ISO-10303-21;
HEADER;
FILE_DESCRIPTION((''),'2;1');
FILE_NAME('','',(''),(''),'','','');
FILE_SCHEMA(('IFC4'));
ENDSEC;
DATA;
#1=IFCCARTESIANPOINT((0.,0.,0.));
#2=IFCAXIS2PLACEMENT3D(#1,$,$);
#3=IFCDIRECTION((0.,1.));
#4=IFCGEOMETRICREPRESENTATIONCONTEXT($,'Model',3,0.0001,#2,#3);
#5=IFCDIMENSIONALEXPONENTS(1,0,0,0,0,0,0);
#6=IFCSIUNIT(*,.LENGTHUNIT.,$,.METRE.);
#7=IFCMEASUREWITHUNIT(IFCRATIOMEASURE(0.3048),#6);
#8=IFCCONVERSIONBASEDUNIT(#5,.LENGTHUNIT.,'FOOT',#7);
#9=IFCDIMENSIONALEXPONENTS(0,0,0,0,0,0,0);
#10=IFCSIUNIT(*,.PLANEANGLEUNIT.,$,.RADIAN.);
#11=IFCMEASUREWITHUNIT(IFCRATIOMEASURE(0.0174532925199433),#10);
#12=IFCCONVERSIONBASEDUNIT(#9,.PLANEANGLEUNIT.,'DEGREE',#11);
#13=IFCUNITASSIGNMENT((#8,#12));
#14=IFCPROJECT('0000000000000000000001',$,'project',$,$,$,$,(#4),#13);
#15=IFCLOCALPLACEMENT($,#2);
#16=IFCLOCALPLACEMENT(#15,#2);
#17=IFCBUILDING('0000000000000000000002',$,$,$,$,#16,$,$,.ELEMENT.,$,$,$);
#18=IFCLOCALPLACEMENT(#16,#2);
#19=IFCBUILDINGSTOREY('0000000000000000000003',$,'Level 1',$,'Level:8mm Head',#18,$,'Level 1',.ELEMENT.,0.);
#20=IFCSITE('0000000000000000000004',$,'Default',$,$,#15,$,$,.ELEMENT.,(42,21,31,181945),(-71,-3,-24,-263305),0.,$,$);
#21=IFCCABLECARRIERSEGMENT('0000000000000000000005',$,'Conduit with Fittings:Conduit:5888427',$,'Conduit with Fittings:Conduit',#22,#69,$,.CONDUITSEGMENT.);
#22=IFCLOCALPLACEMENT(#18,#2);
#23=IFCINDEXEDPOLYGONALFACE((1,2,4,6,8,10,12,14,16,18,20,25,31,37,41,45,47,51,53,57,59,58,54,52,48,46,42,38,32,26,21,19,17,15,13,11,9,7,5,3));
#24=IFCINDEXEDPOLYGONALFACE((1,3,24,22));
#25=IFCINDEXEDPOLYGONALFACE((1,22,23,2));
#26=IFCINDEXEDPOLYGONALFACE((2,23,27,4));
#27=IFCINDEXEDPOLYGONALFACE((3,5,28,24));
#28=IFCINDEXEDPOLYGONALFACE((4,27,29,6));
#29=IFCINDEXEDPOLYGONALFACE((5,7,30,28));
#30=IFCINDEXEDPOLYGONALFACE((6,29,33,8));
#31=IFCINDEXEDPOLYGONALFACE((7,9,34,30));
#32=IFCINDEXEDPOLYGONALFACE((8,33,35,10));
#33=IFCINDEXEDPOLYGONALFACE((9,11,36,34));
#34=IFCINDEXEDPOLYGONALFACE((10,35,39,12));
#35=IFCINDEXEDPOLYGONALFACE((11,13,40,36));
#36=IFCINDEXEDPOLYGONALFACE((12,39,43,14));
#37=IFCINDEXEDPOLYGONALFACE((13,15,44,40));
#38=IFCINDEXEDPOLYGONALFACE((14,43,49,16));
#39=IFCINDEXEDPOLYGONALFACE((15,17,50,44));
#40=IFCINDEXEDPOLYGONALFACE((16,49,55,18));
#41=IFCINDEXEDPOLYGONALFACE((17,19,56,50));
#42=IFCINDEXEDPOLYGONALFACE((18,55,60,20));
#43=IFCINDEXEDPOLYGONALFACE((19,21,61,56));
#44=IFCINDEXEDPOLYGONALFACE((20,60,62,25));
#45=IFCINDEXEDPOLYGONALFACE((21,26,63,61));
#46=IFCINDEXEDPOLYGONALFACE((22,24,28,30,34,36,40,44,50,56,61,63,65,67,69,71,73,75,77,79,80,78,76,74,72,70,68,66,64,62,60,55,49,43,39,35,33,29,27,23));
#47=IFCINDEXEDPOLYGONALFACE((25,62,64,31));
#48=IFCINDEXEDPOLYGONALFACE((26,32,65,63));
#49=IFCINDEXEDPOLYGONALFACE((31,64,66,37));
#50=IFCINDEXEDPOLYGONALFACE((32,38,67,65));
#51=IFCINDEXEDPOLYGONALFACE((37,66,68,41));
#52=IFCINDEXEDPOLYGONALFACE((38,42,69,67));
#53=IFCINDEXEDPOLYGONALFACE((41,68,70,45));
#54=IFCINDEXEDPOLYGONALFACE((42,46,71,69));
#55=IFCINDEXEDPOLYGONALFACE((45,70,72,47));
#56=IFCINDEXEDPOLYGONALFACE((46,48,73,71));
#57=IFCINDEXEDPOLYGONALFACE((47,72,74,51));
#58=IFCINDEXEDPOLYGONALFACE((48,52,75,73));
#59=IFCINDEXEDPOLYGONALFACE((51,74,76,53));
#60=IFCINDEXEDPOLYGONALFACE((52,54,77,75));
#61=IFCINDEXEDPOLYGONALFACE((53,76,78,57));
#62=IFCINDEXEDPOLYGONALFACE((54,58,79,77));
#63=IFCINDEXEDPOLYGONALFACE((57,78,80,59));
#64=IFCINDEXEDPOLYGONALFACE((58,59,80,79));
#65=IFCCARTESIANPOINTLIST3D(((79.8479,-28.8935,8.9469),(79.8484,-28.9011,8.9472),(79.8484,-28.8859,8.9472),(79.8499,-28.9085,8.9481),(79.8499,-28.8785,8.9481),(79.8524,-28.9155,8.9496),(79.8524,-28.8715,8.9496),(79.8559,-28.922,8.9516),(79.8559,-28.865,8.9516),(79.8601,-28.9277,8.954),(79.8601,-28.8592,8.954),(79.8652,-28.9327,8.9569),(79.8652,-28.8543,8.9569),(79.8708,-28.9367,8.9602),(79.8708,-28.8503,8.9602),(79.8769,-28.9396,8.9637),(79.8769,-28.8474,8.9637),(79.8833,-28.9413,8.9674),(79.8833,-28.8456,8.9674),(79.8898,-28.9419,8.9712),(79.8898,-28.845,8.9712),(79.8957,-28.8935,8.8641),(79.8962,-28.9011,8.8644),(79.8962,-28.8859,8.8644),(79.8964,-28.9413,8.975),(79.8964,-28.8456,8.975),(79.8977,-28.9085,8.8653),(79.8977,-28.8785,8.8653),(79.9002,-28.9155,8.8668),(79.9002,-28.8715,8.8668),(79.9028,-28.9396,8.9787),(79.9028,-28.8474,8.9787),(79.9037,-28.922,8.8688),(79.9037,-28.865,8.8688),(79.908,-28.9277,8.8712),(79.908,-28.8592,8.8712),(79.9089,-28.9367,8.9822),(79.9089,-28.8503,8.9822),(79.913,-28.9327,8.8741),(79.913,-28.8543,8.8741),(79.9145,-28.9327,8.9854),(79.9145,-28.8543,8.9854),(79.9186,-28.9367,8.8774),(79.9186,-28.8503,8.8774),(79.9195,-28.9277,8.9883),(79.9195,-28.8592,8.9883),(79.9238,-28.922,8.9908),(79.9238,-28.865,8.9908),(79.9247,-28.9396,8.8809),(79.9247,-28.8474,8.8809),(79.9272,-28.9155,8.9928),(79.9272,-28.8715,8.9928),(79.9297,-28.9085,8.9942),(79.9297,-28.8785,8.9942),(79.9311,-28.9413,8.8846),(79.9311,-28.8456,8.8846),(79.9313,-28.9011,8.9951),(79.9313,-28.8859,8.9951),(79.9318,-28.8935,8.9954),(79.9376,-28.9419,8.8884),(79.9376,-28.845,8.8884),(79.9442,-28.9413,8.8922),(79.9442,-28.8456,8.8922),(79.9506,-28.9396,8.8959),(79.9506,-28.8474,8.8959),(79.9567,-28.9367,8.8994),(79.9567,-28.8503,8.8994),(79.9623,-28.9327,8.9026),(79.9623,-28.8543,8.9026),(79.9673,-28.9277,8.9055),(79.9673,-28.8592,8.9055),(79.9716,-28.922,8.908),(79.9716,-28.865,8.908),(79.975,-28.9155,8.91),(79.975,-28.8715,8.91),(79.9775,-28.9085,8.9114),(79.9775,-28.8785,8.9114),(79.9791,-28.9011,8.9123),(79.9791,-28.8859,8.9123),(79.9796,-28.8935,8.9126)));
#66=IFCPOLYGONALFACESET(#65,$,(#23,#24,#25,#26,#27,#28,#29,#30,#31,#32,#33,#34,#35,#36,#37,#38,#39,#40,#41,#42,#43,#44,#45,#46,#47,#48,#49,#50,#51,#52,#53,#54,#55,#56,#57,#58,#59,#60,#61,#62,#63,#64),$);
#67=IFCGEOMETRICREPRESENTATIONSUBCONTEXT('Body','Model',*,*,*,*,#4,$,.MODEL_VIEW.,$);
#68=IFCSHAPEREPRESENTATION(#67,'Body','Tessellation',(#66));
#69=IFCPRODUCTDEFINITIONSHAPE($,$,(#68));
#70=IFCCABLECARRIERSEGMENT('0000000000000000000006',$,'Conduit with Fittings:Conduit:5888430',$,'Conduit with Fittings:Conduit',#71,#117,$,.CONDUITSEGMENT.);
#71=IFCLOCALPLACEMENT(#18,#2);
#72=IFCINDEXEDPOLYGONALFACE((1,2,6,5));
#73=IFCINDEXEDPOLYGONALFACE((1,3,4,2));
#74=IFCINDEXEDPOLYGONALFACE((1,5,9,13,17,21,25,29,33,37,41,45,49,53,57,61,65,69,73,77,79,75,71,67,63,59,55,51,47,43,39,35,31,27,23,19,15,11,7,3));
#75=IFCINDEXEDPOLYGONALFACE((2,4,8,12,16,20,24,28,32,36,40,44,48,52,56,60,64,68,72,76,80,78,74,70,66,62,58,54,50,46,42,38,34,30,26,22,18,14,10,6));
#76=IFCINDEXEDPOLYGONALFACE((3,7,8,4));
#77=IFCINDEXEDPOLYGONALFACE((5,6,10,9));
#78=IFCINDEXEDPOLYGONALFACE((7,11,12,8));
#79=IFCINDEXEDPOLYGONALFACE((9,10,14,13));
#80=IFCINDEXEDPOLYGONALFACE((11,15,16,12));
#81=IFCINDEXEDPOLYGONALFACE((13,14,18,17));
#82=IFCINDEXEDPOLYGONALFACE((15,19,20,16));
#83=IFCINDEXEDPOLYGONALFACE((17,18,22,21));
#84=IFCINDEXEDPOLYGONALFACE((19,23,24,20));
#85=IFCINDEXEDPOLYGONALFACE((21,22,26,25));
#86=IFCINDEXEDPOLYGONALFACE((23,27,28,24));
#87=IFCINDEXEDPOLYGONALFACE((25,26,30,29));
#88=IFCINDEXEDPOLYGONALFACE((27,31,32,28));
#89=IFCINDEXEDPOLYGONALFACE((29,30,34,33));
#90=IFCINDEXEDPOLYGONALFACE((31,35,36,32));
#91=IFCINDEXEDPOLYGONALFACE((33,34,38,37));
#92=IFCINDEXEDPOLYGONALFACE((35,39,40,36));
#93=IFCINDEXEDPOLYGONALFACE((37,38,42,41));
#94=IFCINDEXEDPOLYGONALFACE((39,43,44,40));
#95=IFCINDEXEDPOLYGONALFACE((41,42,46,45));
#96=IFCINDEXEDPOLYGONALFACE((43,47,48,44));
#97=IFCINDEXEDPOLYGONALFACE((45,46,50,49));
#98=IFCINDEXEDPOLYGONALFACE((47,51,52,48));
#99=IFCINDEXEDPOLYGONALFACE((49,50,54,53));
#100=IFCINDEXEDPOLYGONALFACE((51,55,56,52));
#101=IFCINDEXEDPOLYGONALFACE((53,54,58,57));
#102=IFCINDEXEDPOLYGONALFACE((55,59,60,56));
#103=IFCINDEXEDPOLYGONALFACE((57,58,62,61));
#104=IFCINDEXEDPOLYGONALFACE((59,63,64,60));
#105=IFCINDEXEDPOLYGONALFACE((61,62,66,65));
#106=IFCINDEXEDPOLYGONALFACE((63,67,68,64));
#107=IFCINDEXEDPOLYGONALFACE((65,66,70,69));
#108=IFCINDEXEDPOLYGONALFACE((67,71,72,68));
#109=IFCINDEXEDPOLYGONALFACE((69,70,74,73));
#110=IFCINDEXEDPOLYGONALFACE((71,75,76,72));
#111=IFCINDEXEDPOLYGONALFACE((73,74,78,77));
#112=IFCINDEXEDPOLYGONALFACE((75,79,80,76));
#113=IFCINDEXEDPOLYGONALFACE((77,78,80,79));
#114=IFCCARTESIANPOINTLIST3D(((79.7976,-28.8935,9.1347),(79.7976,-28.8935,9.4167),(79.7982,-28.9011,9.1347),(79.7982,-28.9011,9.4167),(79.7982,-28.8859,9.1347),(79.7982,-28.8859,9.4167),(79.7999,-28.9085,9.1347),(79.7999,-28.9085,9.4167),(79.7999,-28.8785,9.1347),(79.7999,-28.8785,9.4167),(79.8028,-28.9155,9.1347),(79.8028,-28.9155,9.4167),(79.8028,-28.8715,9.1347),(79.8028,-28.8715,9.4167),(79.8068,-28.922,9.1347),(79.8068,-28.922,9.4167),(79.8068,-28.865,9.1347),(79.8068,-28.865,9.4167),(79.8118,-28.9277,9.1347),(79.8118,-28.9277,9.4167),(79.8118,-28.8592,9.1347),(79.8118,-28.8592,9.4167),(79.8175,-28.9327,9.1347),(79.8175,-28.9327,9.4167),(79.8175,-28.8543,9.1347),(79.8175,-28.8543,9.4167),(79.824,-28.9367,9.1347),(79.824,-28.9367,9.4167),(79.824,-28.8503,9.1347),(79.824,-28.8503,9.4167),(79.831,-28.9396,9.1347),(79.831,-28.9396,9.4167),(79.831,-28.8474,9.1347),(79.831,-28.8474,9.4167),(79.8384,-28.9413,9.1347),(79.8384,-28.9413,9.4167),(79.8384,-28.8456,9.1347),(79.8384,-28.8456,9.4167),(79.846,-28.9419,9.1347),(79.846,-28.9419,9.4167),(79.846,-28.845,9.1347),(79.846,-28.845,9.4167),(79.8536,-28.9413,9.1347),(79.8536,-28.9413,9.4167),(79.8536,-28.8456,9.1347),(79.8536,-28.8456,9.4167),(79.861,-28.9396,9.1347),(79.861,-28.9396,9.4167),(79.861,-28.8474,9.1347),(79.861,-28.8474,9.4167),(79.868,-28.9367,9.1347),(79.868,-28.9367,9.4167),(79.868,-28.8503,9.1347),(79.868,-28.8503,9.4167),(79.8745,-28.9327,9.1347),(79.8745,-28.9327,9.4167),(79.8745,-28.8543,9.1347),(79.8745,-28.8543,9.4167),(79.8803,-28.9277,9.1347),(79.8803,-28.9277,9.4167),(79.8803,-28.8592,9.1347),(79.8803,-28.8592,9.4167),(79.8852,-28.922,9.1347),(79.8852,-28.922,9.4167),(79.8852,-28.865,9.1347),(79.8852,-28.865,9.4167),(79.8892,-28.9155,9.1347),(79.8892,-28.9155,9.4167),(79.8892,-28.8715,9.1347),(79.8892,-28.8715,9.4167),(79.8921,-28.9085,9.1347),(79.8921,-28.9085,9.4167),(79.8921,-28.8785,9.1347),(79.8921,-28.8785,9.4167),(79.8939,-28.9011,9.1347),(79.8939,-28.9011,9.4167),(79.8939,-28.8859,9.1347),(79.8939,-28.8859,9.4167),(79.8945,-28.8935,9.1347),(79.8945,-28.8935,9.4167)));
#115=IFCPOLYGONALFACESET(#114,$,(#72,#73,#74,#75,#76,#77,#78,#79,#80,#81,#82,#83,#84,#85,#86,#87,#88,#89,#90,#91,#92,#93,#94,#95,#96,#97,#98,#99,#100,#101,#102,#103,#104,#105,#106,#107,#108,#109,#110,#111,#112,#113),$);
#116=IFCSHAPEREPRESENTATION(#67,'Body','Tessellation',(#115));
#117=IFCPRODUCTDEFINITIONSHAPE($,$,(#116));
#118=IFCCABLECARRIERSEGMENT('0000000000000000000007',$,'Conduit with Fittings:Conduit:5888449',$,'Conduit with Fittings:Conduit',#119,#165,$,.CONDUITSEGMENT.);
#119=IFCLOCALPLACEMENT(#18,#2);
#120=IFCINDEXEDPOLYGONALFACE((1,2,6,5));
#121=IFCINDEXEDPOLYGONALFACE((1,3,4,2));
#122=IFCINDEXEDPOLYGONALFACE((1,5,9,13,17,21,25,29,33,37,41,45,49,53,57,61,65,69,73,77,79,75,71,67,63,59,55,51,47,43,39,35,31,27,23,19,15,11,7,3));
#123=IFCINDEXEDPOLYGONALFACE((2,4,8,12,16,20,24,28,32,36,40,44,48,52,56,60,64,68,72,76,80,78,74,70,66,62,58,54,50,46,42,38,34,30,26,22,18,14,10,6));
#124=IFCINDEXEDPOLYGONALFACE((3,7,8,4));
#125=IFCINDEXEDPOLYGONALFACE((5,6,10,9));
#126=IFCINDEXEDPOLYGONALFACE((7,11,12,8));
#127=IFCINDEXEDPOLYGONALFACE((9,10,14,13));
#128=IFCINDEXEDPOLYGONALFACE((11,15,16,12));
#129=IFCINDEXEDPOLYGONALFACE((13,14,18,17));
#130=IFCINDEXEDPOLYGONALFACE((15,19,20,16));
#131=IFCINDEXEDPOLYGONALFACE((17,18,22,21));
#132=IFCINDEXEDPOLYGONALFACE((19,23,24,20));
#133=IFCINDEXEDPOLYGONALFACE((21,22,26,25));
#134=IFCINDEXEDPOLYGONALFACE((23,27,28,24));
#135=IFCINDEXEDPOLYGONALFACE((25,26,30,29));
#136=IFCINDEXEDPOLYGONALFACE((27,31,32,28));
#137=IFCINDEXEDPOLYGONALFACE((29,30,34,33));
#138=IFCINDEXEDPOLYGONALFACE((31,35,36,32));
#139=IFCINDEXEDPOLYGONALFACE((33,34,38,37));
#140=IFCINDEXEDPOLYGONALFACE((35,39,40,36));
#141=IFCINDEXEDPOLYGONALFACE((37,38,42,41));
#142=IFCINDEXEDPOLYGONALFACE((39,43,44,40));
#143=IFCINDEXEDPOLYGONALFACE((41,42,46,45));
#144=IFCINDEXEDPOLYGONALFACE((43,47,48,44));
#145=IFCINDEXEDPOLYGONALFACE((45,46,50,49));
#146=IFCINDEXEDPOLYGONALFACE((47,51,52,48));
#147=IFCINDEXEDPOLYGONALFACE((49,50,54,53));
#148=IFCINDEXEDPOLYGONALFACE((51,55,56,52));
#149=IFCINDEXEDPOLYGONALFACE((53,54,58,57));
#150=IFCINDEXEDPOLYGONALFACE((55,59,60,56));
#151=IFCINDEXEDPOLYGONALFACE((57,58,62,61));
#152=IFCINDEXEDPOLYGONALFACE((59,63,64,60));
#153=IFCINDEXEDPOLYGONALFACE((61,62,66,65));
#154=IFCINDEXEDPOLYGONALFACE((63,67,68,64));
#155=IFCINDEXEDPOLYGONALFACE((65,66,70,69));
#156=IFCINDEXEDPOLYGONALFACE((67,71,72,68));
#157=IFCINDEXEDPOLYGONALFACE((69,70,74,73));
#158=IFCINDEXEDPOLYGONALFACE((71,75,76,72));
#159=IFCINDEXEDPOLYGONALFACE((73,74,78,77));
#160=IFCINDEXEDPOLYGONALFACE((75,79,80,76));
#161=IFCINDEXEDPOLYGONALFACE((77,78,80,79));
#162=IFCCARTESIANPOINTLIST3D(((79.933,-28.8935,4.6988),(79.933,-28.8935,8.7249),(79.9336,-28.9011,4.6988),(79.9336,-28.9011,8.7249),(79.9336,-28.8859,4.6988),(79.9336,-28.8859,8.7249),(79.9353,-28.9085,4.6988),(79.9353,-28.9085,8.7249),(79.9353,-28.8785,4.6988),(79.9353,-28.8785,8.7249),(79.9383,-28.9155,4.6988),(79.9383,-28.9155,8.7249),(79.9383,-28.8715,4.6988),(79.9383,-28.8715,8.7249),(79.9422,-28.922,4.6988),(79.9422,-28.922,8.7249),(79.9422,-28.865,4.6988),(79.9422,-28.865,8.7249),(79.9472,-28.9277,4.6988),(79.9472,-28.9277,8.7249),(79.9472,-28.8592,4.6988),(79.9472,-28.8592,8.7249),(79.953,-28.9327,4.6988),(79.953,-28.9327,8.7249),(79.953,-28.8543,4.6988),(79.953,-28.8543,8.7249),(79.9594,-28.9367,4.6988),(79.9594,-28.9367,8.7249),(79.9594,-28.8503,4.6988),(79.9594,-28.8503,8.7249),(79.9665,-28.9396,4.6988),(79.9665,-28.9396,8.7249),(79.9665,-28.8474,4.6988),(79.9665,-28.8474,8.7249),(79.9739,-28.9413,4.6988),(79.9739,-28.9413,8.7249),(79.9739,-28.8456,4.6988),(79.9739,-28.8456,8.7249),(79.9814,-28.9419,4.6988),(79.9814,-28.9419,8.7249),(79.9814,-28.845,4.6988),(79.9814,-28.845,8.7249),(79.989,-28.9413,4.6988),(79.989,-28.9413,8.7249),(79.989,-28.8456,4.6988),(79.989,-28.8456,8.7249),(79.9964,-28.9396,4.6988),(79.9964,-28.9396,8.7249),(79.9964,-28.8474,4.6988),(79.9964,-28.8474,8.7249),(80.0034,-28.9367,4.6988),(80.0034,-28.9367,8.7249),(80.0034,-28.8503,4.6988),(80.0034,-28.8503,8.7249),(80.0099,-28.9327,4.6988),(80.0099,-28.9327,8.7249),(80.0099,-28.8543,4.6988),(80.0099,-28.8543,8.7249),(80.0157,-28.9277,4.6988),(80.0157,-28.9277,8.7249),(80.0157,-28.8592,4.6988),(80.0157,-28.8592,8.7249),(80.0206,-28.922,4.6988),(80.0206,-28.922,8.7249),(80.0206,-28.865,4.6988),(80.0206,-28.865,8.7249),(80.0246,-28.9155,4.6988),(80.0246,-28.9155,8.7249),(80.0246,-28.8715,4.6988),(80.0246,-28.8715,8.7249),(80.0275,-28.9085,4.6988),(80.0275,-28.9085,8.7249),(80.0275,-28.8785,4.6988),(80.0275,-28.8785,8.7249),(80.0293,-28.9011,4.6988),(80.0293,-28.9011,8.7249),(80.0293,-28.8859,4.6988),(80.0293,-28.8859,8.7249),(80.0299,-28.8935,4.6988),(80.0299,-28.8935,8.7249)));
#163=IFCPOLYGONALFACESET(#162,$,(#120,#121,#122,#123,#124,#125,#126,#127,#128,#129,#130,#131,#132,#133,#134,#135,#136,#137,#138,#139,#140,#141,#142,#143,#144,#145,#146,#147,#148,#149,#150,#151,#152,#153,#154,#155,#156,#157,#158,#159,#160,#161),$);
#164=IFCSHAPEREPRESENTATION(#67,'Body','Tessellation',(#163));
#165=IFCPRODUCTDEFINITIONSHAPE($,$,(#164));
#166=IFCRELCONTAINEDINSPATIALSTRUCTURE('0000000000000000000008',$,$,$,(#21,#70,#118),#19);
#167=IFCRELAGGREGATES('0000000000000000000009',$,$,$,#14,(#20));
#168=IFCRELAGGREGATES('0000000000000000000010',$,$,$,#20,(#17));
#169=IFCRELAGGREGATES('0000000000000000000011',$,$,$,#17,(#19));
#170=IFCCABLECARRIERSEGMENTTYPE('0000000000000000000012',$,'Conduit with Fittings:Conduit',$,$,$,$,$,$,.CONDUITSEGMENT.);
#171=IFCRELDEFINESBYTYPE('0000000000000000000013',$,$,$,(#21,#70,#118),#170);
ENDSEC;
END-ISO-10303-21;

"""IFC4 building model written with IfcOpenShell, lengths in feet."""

from ifc_helpers import new_model, entity, si_unit, converted_unit, direction, frame, origin, place, context, subcontext, project, spatial, indexed_curve, outline, extrude, type_object, element, save


model = new_model("IFC4")

# Units and contexts
model_context = context("Model", 3, precision=0.0001, world=origin(), true_north=direction((0.0, 1.0)))
body_context = subcontext(model_context, "Body", "Model", "MODEL_VIEW")
ifc_project = project(units=[converted_unit("LENGTHUNIT", "FOOT", entity("IfcRatioMeasure", 0.3048), si_unit("LENGTHUNIT", "METRE"), dimensions=[1, 0, 0, 0, 0, 0, 0]), converted_unit("PLANEANGLEUNIT", "DEGREE", entity("IfcRatioMeasure", 0.0174532925199433), si_unit("PLANEANGLEUNIT", "RADIAN"), dimensions=[0, 0, 0, 0, 0, 0, 0])], contexts=[model_context])

# Site, building, storey
site_placement = place(None, origin())
site = spatial("IfcSite", under=ifc_project, at=site_placement, Name="Default", CompositionType="ELEMENT", RefLatitude=(42, 21, 31, 181945), RefLongitude=(-71, -3, -24, -263305), RefElevation=0.0)
building_placement = place(site_placement, origin())
building = spatial("IfcBuilding", under=site, at=building_placement, CompositionType="ELEMENT")
storey_placement = place(building_placement, origin())
storey = spatial("IfcBuildingStorey", under=building, at=storey_placement, Name="Level 1", ObjectType="Level:8mm Head", LongName="Level 1", CompositionType="ELEMENT", Elevation=0.0)

# Cable carrier segments
cable_carrier_segment_type = type_object("IfcCableCarrierSegmentType", Name="Conduit with Fittings:Conduit", PredefinedType="CONDUITSEGMENT")
cable_carrier_segment_1_placement = place(storey_placement, origin())
element("IfcCableCarrierSegment", 1, at=cable_carrier_segment_1_placement, inside=storey, type_object=cable_carrier_segment_type, Name="Conduit with Fittings:Conduit:5888427", ObjectType="Conduit with Fittings:Conduit", PredefinedType="CONDUITSEGMENT", context=body_context, shape_type="SweptSolid", body=[
    extrude(outline(indexed_curve([(0.0485, 0.0), (0.0479, 0.0076), (0.0461, 0.015), (0.0432, 0.022), (0.0392, 0.0285), (0.0343, 0.0343), (0.0285, 0.0392), (0.022, 0.0432), (0.015, 0.0461), (0.0076, 0.0479), (0.0, 0.0485), (-0.0076, 0.0479), (-0.015, 0.0461), (-0.022, 0.0432), (-0.0285, 0.0392), (-0.0343, 0.0343), (-0.0392, 0.0285), (-0.0432, 0.022), (-0.0461, 0.015), (-0.0479, 0.0076), (-0.0485, 0.0), (-0.0479, -0.0076), (-0.0461, -0.015), (-0.0432, -0.022), (-0.0392, -0.0285), (-0.0343, -0.0343), (-0.0285, -0.0392), (-0.022, -0.0432), (-0.015, -0.0461), (-0.0076, -0.0479), (0.0, -0.0485), (0.0076, -0.0479), (0.015, -0.0461), (0.022, -0.0432), (0.0285, -0.0392), (0.0343, -0.0343), (0.0392, -0.0285), (0.0432, -0.022), (0.0461, -0.015), (0.0479, -0.0076), (0.0485, 0.0)], self_intersect=False)), frame((79.9376, -28.8935, 8.8884), z_axis=(-0.5, 0.0, 0.866025), x_axis=(0.0, 1.0, 0.0)), (0.0, 0.0, 1.0), 0.0956),
])
cable_carrier_segment_2_placement = place(storey_placement, origin())
element("IfcCableCarrierSegment", 2, at=cable_carrier_segment_2_placement, inside=storey, type_object=cable_carrier_segment_type, Name="Conduit with Fittings:Conduit:5888430", ObjectType="Conduit with Fittings:Conduit", PredefinedType="CONDUITSEGMENT", context=body_context, shape_type="SweptSolid", body=[
    extrude(outline(indexed_curve([(0.0485, 0.0), (0.0479, 0.0076), (0.0461, 0.015), (0.0432, 0.022), (0.0392, 0.0285), (0.0343, 0.0343), (0.0285, 0.0392), (0.022, 0.0432), (0.015, 0.0461), (0.0076, 0.0479), (0.0, 0.0485), (-0.0076, 0.0479), (-0.015, 0.0461), (-0.022, 0.0432), (-0.0285, 0.0392), (-0.0343, 0.0343), (-0.0392, 0.0285), (-0.0432, 0.022), (-0.0461, 0.015), (-0.0479, 0.0076), (-0.0485, 0.0), (-0.0479, -0.0076), (-0.0461, -0.015), (-0.0432, -0.022), (-0.0392, -0.0285), (-0.0343, -0.0343), (-0.0285, -0.0392), (-0.022, -0.0432), (-0.015, -0.0461), (-0.0076, -0.0479), (0.0, -0.0485), (0.0076, -0.0479), (0.015, -0.0461), (0.022, -0.0432), (0.0285, -0.0392), (0.0343, -0.0343), (0.0392, -0.0285), (0.0432, -0.022), (0.0461, -0.015), (0.0479, -0.0076), (0.0485, 0.0)], self_intersect=False)), frame((79.846, -28.8935, 9.1347), z_axis=(0.0, 0.0, 1.0), x_axis=(-1.0, 0.0, 0.0)), (0.0, 0.0, 1.0), 0.282),
])
cable_carrier_segment_3_placement = place(storey_placement, origin())
element("IfcCableCarrierSegment", 3, at=cable_carrier_segment_3_placement, inside=storey, type_object=cable_carrier_segment_type, Name="Conduit with Fittings:Conduit:5888449", ObjectType="Conduit with Fittings:Conduit", PredefinedType="CONDUITSEGMENT", context=body_context, shape_type="SweptSolid", body=[
    extrude(outline(indexed_curve([(0.0485, 0.0), (0.0479, 0.0076), (0.0461, 0.015), (0.0432, 0.022), (0.0392, 0.0285), (0.0343, 0.0343), (0.0285, 0.0392), (0.022, 0.0432), (0.015, 0.0461), (0.0076, 0.0479), (0.0, 0.0485), (-0.0076, 0.0479), (-0.015, 0.0461), (-0.022, 0.0432), (-0.0285, 0.0392), (-0.0343, 0.0343), (-0.0392, 0.0285), (-0.0432, 0.022), (-0.0461, 0.015), (-0.0479, 0.0076), (-0.0485, 0.0), (-0.0479, -0.0076), (-0.0461, -0.015), (-0.0432, -0.022), (-0.0392, -0.0285), (-0.0343, -0.0343), (-0.0285, -0.0392), (-0.022, -0.0432), (-0.015, -0.0461), (-0.0076, -0.0479), (0.0, -0.0485), (0.0076, -0.0479), (0.015, -0.0461), (0.022, -0.0432), (0.0285, -0.0392), (0.0343, -0.0343), (0.0392, -0.0285), (0.0432, -0.022), (0.0461, -0.015), (0.0479, -0.0076), (0.0485, 0.0)], self_intersect=False)), frame((79.9814, -28.8935, 4.6988)), (0.0, 0.0, 1.0), 4.0261),
])

save(model, "model.ifc")
